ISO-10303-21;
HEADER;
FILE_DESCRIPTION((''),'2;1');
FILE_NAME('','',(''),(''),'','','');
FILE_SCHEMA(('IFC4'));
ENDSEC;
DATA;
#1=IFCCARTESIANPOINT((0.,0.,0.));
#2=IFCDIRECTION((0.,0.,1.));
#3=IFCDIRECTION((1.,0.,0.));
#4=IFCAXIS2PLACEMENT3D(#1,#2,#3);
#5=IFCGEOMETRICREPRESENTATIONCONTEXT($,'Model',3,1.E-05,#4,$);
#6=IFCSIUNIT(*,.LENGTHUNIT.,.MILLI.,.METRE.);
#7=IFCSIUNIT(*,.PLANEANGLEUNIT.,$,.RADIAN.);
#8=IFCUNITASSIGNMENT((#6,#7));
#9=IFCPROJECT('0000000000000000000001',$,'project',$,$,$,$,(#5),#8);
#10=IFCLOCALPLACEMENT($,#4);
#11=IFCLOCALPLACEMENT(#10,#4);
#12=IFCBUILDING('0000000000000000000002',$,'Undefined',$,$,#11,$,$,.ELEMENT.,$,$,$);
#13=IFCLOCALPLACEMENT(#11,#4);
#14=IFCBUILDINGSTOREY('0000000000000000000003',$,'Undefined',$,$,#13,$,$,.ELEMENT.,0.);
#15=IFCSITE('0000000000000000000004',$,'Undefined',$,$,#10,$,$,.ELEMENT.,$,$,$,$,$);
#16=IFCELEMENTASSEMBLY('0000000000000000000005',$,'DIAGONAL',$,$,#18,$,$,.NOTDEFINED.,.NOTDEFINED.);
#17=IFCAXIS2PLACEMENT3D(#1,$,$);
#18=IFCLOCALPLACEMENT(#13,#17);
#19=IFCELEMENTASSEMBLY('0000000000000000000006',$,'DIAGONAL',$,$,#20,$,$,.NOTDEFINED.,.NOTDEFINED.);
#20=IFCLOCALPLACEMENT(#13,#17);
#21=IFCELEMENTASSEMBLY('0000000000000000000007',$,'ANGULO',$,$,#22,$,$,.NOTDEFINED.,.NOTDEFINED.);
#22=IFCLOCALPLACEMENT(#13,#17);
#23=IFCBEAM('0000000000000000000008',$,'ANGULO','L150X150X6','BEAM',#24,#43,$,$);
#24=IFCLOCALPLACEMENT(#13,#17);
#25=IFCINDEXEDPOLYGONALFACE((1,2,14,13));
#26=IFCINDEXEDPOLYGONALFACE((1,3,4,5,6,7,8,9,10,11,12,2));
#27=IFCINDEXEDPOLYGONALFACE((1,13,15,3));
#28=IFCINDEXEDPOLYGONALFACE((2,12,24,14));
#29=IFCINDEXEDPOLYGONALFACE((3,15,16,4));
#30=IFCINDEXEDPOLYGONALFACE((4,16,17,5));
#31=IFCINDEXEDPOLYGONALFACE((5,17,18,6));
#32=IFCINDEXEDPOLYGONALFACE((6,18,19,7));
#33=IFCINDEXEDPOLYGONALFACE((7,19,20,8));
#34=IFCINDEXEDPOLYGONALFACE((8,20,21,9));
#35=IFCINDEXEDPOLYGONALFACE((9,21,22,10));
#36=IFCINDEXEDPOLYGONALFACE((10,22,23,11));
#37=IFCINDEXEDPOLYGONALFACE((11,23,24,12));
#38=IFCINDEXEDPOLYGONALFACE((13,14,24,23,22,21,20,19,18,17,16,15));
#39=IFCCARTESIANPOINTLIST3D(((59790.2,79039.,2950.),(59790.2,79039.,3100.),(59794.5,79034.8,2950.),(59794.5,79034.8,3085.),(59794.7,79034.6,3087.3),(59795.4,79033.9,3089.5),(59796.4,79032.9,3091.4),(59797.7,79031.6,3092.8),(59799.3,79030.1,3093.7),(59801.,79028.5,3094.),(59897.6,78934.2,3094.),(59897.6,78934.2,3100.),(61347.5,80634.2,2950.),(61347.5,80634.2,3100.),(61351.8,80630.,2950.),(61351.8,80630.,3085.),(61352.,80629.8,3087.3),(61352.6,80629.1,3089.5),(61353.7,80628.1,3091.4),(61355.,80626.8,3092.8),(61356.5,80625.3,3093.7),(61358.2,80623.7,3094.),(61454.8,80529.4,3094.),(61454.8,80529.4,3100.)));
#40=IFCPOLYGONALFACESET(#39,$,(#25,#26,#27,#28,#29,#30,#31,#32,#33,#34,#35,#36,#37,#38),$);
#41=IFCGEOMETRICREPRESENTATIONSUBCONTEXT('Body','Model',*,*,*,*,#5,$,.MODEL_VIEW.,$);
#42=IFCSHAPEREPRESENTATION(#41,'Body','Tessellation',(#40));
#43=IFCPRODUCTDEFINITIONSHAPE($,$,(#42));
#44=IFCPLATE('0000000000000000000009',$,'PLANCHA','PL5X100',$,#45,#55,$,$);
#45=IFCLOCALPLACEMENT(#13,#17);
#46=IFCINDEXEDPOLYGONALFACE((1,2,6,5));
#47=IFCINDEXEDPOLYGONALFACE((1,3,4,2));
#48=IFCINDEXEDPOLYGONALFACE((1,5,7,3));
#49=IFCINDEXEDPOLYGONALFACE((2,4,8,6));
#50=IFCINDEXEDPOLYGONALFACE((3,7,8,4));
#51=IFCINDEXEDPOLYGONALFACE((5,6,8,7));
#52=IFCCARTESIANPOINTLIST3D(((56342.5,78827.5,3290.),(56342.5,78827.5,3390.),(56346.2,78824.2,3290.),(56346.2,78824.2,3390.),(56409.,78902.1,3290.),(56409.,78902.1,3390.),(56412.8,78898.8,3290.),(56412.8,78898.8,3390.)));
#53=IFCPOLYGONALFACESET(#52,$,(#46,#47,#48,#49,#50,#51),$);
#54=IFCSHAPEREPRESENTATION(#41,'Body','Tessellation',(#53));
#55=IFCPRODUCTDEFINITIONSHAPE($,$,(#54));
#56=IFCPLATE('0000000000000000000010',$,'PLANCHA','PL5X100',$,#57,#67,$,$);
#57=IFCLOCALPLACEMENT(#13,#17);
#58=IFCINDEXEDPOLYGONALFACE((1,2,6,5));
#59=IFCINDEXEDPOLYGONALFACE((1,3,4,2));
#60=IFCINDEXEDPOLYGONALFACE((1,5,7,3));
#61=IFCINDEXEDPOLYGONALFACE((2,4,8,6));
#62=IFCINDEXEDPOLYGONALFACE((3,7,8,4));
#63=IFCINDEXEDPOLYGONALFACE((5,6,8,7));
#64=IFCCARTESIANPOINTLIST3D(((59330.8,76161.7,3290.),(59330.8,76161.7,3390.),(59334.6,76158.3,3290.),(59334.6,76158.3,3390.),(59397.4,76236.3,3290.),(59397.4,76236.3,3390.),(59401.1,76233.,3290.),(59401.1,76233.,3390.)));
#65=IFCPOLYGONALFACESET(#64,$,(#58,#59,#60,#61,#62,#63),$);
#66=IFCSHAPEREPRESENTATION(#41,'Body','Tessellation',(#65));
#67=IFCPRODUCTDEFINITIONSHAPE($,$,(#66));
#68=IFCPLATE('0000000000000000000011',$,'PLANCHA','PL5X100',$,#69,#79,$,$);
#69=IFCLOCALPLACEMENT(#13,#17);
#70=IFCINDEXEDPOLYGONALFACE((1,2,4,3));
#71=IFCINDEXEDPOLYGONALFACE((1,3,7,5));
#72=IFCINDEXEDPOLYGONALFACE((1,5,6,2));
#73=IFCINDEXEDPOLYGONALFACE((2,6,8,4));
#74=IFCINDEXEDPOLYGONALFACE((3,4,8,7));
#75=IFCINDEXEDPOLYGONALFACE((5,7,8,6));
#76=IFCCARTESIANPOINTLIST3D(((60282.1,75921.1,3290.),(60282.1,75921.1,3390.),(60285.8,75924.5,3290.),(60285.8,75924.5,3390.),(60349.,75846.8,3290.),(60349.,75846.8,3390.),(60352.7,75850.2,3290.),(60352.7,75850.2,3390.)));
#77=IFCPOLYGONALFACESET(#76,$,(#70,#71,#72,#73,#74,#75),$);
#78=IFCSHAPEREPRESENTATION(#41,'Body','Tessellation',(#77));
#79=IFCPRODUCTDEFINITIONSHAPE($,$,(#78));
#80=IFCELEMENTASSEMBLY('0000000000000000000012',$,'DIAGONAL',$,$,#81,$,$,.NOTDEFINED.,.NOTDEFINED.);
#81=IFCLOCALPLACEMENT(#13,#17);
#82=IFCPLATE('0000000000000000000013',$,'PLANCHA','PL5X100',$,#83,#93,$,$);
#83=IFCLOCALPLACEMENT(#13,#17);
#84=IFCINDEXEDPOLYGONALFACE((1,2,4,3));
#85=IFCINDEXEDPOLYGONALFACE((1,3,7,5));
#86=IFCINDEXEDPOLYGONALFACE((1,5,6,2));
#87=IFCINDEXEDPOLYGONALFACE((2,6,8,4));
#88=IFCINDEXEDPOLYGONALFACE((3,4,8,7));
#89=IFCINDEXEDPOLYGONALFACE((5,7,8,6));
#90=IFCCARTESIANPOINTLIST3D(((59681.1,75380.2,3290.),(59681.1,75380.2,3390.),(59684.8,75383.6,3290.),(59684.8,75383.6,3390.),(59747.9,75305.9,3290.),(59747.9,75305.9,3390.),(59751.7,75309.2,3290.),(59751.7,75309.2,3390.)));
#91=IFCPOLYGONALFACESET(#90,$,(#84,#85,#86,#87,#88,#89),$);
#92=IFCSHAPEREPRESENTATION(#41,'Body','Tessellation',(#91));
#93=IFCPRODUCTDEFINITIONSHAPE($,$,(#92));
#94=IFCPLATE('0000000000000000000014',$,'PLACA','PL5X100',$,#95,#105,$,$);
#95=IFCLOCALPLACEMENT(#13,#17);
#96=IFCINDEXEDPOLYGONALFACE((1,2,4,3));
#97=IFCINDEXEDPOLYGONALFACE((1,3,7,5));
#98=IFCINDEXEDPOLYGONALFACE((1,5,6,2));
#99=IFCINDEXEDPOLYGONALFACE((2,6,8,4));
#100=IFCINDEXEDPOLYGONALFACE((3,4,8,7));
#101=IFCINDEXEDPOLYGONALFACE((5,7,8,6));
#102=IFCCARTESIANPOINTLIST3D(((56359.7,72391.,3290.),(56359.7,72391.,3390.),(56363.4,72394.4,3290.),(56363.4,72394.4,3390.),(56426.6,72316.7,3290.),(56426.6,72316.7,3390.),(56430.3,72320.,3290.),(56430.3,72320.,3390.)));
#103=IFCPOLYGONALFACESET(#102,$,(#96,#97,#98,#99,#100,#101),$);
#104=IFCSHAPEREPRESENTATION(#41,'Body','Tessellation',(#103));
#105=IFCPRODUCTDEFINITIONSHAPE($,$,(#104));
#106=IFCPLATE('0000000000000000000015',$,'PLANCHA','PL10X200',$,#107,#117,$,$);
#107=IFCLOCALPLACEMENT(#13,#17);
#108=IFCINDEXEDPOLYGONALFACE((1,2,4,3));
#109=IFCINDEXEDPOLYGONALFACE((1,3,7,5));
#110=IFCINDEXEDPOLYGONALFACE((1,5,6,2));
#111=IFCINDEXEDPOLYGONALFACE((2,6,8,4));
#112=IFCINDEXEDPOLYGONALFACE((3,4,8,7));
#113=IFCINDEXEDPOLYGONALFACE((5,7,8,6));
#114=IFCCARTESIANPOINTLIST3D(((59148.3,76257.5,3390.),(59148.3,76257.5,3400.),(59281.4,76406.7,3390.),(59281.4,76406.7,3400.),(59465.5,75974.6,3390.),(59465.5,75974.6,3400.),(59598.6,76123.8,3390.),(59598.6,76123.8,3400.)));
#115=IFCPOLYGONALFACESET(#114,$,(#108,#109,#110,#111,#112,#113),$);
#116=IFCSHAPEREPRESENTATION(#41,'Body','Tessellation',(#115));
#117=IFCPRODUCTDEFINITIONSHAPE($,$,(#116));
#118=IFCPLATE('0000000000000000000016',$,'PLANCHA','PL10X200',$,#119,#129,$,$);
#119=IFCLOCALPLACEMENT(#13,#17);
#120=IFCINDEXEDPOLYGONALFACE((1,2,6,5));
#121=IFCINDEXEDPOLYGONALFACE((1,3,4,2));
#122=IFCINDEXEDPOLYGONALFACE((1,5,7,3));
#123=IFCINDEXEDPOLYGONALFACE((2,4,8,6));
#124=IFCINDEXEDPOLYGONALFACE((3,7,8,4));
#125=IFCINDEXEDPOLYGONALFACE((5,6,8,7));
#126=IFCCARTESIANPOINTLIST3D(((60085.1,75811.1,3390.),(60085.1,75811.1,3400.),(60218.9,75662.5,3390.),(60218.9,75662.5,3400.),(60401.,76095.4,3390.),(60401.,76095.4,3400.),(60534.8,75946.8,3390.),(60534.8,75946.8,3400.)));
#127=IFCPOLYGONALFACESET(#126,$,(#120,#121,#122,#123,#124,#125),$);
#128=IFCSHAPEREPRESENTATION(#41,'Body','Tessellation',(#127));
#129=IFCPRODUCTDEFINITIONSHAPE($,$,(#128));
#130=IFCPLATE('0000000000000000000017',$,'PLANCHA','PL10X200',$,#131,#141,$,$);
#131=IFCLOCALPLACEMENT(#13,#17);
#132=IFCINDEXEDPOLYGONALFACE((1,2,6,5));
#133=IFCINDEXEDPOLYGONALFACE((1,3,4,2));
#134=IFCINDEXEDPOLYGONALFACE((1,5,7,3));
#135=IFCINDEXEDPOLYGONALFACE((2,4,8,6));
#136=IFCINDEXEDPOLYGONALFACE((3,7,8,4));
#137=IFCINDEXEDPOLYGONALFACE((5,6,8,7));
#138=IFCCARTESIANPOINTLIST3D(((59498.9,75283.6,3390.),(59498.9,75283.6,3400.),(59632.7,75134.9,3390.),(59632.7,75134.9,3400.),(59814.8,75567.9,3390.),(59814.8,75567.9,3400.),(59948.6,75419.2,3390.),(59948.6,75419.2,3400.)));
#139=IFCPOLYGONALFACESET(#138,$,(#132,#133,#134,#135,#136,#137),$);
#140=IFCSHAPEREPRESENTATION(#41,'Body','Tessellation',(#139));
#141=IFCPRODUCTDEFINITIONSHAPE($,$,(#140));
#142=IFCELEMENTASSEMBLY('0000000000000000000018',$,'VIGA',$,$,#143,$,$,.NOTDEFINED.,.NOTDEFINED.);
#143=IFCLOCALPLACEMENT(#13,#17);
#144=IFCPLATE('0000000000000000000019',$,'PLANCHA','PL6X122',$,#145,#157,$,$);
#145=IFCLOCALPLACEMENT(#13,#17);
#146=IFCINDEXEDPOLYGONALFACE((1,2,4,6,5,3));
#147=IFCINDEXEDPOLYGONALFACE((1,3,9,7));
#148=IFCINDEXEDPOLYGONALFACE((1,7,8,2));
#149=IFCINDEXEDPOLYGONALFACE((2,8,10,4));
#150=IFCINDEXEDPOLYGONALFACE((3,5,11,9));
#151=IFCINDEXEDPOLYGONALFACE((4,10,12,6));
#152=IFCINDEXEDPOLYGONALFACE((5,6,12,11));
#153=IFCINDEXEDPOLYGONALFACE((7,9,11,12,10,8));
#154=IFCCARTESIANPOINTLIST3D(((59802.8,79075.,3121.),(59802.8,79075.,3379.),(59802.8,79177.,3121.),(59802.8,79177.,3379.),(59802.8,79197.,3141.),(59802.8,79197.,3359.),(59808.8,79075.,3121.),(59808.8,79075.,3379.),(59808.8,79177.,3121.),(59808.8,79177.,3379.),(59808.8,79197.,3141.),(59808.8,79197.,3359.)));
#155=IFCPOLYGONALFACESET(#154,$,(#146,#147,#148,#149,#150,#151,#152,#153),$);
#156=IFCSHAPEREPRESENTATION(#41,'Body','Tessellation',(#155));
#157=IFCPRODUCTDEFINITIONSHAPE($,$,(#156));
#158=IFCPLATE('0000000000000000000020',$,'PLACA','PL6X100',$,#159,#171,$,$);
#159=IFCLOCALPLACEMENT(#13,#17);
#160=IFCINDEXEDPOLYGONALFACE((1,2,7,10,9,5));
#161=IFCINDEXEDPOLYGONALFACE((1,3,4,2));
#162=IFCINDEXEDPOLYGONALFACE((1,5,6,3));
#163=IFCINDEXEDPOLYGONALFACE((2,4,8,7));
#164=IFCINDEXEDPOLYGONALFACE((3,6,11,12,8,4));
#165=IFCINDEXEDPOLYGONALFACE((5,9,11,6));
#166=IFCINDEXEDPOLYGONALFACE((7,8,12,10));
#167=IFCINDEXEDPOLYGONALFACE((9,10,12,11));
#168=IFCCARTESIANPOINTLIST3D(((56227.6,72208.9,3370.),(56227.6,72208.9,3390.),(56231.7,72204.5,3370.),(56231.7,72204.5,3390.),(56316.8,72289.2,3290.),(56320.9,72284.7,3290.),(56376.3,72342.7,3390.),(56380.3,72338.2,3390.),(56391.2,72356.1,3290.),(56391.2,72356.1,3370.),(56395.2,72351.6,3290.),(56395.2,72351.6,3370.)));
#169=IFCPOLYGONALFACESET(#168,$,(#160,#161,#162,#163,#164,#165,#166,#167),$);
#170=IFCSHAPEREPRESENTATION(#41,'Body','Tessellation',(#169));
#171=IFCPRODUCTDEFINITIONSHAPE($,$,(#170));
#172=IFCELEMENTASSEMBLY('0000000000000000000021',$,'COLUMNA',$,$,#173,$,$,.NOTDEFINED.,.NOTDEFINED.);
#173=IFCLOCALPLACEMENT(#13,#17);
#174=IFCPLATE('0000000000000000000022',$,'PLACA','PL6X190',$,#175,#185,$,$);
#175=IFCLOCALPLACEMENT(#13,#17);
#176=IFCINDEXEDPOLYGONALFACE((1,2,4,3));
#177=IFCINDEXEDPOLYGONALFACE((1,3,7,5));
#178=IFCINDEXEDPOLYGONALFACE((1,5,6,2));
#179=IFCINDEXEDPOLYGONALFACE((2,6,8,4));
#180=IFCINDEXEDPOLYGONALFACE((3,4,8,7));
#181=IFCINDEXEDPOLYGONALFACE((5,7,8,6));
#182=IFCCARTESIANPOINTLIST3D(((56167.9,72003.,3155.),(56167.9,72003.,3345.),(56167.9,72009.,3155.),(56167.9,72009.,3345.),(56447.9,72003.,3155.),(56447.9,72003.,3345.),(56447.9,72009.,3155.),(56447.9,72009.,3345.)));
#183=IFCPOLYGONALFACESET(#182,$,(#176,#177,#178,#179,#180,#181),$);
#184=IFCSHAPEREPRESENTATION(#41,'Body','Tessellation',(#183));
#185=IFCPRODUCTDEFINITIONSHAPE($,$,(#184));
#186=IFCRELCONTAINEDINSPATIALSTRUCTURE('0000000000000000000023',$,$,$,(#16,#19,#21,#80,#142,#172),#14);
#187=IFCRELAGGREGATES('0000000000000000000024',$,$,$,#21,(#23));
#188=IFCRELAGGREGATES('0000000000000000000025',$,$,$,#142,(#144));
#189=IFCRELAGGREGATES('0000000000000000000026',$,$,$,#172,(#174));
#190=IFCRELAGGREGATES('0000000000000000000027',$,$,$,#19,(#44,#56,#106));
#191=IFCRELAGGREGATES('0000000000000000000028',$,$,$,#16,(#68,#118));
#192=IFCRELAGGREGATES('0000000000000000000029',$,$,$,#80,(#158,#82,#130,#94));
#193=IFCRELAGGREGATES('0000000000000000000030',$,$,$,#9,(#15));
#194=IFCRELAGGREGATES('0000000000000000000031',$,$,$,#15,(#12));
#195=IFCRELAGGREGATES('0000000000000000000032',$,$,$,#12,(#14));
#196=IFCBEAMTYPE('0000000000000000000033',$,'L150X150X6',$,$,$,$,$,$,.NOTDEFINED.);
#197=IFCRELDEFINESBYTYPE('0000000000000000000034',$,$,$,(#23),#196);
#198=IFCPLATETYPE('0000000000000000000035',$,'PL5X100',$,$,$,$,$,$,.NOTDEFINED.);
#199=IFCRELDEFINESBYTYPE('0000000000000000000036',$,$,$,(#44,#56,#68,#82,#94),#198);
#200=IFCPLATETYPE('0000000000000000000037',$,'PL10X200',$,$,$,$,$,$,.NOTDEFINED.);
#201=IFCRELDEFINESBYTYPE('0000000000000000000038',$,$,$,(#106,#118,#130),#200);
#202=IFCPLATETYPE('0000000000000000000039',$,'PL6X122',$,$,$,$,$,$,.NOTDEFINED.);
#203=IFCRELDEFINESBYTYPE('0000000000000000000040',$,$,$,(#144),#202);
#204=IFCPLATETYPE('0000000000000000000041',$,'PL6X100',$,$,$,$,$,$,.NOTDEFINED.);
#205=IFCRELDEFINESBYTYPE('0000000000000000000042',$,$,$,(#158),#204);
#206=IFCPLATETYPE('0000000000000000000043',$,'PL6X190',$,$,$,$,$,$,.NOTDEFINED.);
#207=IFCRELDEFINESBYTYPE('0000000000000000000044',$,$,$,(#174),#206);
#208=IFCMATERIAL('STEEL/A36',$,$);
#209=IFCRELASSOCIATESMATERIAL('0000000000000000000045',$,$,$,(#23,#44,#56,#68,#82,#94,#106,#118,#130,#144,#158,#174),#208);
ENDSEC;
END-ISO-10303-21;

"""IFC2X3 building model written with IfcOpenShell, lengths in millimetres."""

from ifc_helpers import new_model, si_unit, frame, origin_with_axes, origin_2d_with_axis, place, context, subcontext, project, spatial, polyline, l_section, outline, extrude, material, type_object, element, aggregate, save


model = new_model("IFC2X3")

# Units and contexts
model_context = context("Model", 3, precision=1e-05, world=origin_with_axes())
body_context = subcontext(model_context, "Body", "Model", "MODEL_VIEW")
ifc_project = project(units=[si_unit("LENGTHUNIT", "METRE", prefix="MILLI"), si_unit("PLANEANGLEUNIT", "RADIAN")], contexts=[model_context])

# Site, building, storey
site_placement = place(None, origin_with_axes())
site = spatial("IfcSite", under=ifc_project, at=site_placement, Name="Undefined", CompositionType="ELEMENT")
building_placement = place(site_placement, origin_with_axes())
building = spatial("IfcBuilding", under=site, at=building_placement, Name="Undefined", CompositionType="ELEMENT")
storey_placement = place(building_placement, origin_with_axes())
storey = spatial("IfcBuildingStorey", under=building, at=storey_placement, Name="Undefined", CompositionType="ELEMENT", Elevation=0.0)

# Element assemblies, beam
ifc_material_1 = material(Name="STEEL/A36")
assembly_1_placement = place(storey_placement, origin_with_axes())
assembly_1 = element("IfcElementAssembly", 1, at=assembly_1_placement, inside=storey, Name="DIAGONAL", AssemblyPlace="NOTDEFINED", PredefinedType="NOTDEFINED")
assembly_2_placement = place(storey_placement, origin_with_axes())
assembly_2 = element("IfcElementAssembly", 2, at=assembly_2_placement, inside=storey, Name="DIAGONAL", AssemblyPlace="NOTDEFINED", PredefinedType="NOTDEFINED")
assembly_3_placement = place(storey_placement, origin_with_axes())
assembly_3 = element("IfcElementAssembly", 3, at=assembly_3_placement, inside=storey, Name="ANGULO", AssemblyPlace="NOTDEFINED", PredefinedType="NOTDEFINED")
beam_type_1 = type_object("IfcBeamType", Name="L150X150X6", PredefinedType="NOTDEFINED")
beam_1_placement = place(assembly_3_placement, frame((59843.9, 78986.6, 3025.0), z_axis=(0.71557, -0.698541, 0.0), x_axis=(0.698541, 0.715571, 0.0)))
beam_1 = element("IfcBeam", 4, at=beam_1_placement, type_object=beam_type_1, material=ifc_material_1, Name="ANGULO", Description="L150X150X6", ObjectType="BEAM", context=body_context, shape_type="SweptSolid", body=[
    extrude(l_section(Depth=150.0, Width=150.0, Thickness=6.0, FilletRadius=9.0, at=origin_2d_with_axis()), frame((2229.3, 0.0, 0.0), z_axis=(-1.0, 0.0, 0.0), x_axis=(0.0, -1.0, 0.0)), (0.0, 0.0, 1.0), 2229.3),
])
aggregate(assembly_3, [beam_1])

# Plates
plate_type_1 = type_object("IfcPlateType", Name="PL5X100", PredefinedType="NOTDEFINED")
plate_1_placement = place(assembly_2_placement, frame((56377.6, 78863.1, 3390.0), z_axis=(0.74623, -0.665688, 0.0), x_axis=(0.0, 0.0, -1.0)))
plate_1 = element("IfcPlate", 5, at=plate_1_placement, type_object=plate_type_1, material=ifc_material_1, Name="PLANCHA", Description="PL5X100", context=body_context, shape_type="SweptSolid", body=[
    extrude(outline(polyline([(0.0, -50.0), (0.0, 50.0), (100.0, 50.0), (100.0, -50.0), (0.0, -50.0)])), frame((0.0, 0.0, -2.5), z_axis=(0.0, 0.0, 1.0), x_axis=(1.0, 0.0, 0.0)), (0.0, 0.0, 1.0), 5.0),
])
plate_2_placement = place(assembly_2_placement, frame((59366.0, 76197.3, 3390.0), z_axis=(-0.74623, 0.665688, 0.0), x_axis=(0.0, 0.0, -1.0)))
plate_2 = element("IfcPlate", 6, at=plate_2_placement, type_object=plate_type_1, material=ifc_material_1, Name="PLANCHA", Description="PL5X100", context=body_context, shape_type="SweptSolid", body=[
    extrude(outline(polyline([(0.0, -50.0), (0.0, 50.0), (100.0, 50.0), (100.0, -50.0), (0.0, -50.0)])), frame((0.0, 0.0, -2.5), z_axis=(0.0, 0.0, 1.0), x_axis=(1.0, 0.0, 0.0)), (0.0, 0.0, 1.0), 5.0),
])
plate_3_placement = place(assembly_1_placement, frame((60317.4, 75885.7, 3390.0), z_axis=(0.743294, 0.668965, 0.0), x_axis=(0.0, 0.0, -1.0)))
plate_3 = element("IfcPlate", 7, at=plate_3_placement, type_object=plate_type_1, material=ifc_material_1, Name="PLANCHA", Description="PL5X100", context=body_context, shape_type="SweptSolid", body=[
    extrude(outline(polyline([(0.0, -50.0), (0.0, 50.0), (100.0, 50.0), (100.0, -50.0), (0.0, -50.0)])), frame((0.0, 0.0, -2.5), z_axis=(0.0, 0.0, 1.0), x_axis=(1.0, 0.0, 0.0)), (0.0, 0.0, 1.0), 5.0),
])

# Element assembly, plates
assembly_4_placement = place(storey_placement, origin_with_axes())
assembly_4 = element("IfcElementAssembly", 8, at=assembly_4_placement, inside=storey, Name="DIAGONAL", AssemblyPlace="NOTDEFINED", PredefinedType="NOTDEFINED")
plate_4_placement = place(assembly_4_placement, frame((59716.4, 75344.7, 3390.0), z_axis=(-0.743294, -0.668964, 0.0), x_axis=(0.0, 0.0, -1.0)))
plate_4 = element("IfcPlate", 9, at=plate_4_placement, type_object=plate_type_1, material=ifc_material_1, Name="PLANCHA", Description="PL5X100", context=body_context, shape_type="SweptSolid", body=[
    extrude(outline(polyline([(0.0, -50.0), (0.0, 50.0), (100.0, 50.0), (100.0, -50.0), (0.0, -50.0)])), frame((0.0, 0.0, -2.5), z_axis=(0.0, 0.0, 1.0), x_axis=(1.0, 0.0, 0.0)), (0.0, 0.0, 1.0), 5.0),
])
plate_5_placement = place(assembly_4_placement, frame((56428.5, 72318.4, 3390.0), z_axis=(0.743294, 0.668965, 0.0), x_axis=(0.0, 0.0, -1.0)))
plate_5 = element("IfcPlate", 10, at=plate_5_placement, type_object=plate_type_1, material=ifc_material_1, Name="PLACA", Description="PL5X100", context=body_context, shape_type="SweptSolid", body=[
    extrude(outline(polyline([(0.0, 0.0), (100.0, 0.0), (100.0, 100.0), (0.0, 100.0), (0.0, 0.0)])), frame((0.0, 0.0, -2.5), z_axis=(0.0, 0.0, 1.0), x_axis=(1.0, 0.0, 0.0)), (0.0, 0.0, 1.0), 5.0),
])

# Plates
plate_type_2 = type_object("IfcPlateType", Name="PL10X200", PredefinedType="NOTDEFINED")
plate_6_placement = place(assembly_2_placement, frame((59532.0, 76049.2, 3395.0), z_axis=(0.0, 0.0, 1.0), x_axis=(-0.74623, 0.665688, 0.0)))
plate_6 = element("IfcPlate", 11, at=plate_6_placement, type_object=plate_type_2, material=ifc_material_1, Name="PLANCHA", Description="PL10X200", context=body_context, shape_type="SweptSolid", body=[
    extrude(outline(polyline([(0.0, -100.0), (0.0, 100.0), (425.0, 100.0), (425.0, -100.0), (0.0, -100.0)])), frame((0.0, 0.0, -5.0), z_axis=(0.0, 0.0, 1.0), x_axis=(1.0, 0.0, 0.0)), (0.0, 0.0, 1.0), 10.0),
])
plate_7_placement = place(assembly_1_placement, frame((60152.0, 75736.8, 3395.0), z_axis=(0.0, 0.0, 1.0), x_axis=(0.743294, 0.668965, 0.0)))
plate_7 = element("IfcPlate", 12, at=plate_7_placement, type_object=plate_type_2, material=ifc_material_1, Name="PLANCHA", Description="PL10X200", context=body_context, shape_type="SweptSolid", body=[
    extrude(outline(polyline([(0.0, -100.0), (0.0, 100.0), (425.0, 100.0), (425.0, -100.0), (0.0, -100.0)])), frame((0.0, 0.0, -5.0), z_axis=(0.0, 0.0, 1.0), x_axis=(1.0, 0.0, 0.0)), (0.0, 0.0, 1.0), 10.0),
])
plate_8_placement = place(assembly_4_placement, frame((59881.7, 75493.6, 3395.0), z_axis=(0.0, 0.0, 1.0), x_axis=(-0.743294, -0.668964, 0.0)))
plate_8 = element("IfcPlate", 13, at=plate_8_placement, type_object=plate_type_2, material=ifc_material_1, Name="PLANCHA", Description="PL10X200", context=body_context, shape_type="SweptSolid", body=[
    extrude(outline(polyline([(0.0, -100.0), (0.0, 100.0), (425.0, 100.0), (425.0, -100.0), (0.0, -100.0)])), frame((0.0, 0.0, -5.0), z_axis=(0.0, 0.0, 1.0), x_axis=(1.0, 0.0, 0.0)), (0.0, 0.0, 1.0), 10.0),
])

# Element assembly, plate
assembly_5_placement = place(storey_placement, origin_with_axes())
assembly_5 = element("IfcElementAssembly", 14, at=assembly_5_placement, inside=storey, Name="VIGA", AssemblyPlace="NOTDEFINED", PredefinedType="NOTDEFINED")
plate_type_3 = type_object("IfcPlateType", Name="PL6X122", PredefinedType="NOTDEFINED")
plate_9_placement = place(assembly_5_placement, frame((59805.8, 79075.0, 3121.0), z_axis=(1.0, 0.0, 0.0), x_axis=(0.0, 1.0, 0.0)))
plate_9 = element("IfcPlate", 15, at=plate_9_placement, type_object=plate_type_3, material=ifc_material_1, Name="PLANCHA", Description="PL6X122", context=body_context, shape_type="SweptSolid", body=[
    extrude(outline(polyline([(0.0, 0.0), (102.0, 0.0), (122.0, 20.0), (122.0, 238.0), (102.0, 258.0), (0.0, 258.0), (0.0, 0.0)])), frame((0.0, 0.0, -3.0), z_axis=(0.0, 0.0, 1.0), x_axis=(1.0, 0.0, 0.0)), (0.0, 0.0, 1.0), 6.0),
])
aggregate(assembly_5, [plate_9])

# Plate
plate_type_4 = type_object("IfcPlateType", Name="PL6X100", PredefinedType="NOTDEFINED")
plate_10_placement = place(assembly_4_placement, frame((56229.7, 72206.7, 3290.0), z_axis=(0.668964, -0.743294, 0.0), x_axis=(0.743294, 0.668965, 0.0)))
plate_10 = element("IfcPlate", 16, at=plate_10_placement, type_object=plate_type_4, material=ifc_material_1, Name="PLACA", Description="PL6X100", context=body_context, shape_type="SweptSolid", body=[
    extrude(outline(polyline([(0.0, 80.0), (120.0, 0.0), (220.0, 0.0), (220.0, 80.0), (200.0, 100.0), (0.0, 100.0), (0.0, 80.0)])), frame((0.0, 0.0, -3.0), z_axis=(0.0, 0.0, 1.0), x_axis=(1.0, 0.0, 0.0)), (0.0, 0.0, 1.0), 6.0),
])

# Element assembly, plate
assembly_6_placement = place(storey_placement, origin_with_axes())
assembly_6 = element("IfcElementAssembly", 17, at=assembly_6_placement, inside=storey, Name="COLUMNA", AssemblyPlace="NOTDEFINED", PredefinedType="NOTDEFINED")
plate_type_5 = type_object("IfcPlateType", Name="PL6X190", PredefinedType="NOTDEFINED")
plate_11_placement = place(assembly_6_placement, frame((56447.9, 72006.0, 3250.0), z_axis=(0.0, 1.0, 0.0), x_axis=(-1.0, 0.0, 0.0)))
plate_11 = element("IfcPlate", 18, at=plate_11_placement, type_object=plate_type_5, material=ifc_material_1, Name="PLACA", Description="PL6X190", context=body_context, shape_type="SweptSolid", body=[
    extrude(outline(polyline([(0.0, -95.0), (0.0, 95.0), (280.0, 95.0), (280.0, -95.0), (0.0, -95.0)])), frame((0.0, 0.0, -3.0), z_axis=(0.0, 0.0, 1.0), x_axis=(1.0, 0.0, 0.0)), (0.0, 0.0, 1.0), 6.0),
])

aggregate(assembly_6, [plate_11])
aggregate(assembly_2, [plate_1, plate_2, plate_6])
aggregate(assembly_1, [plate_3, plate_7])
aggregate(assembly_4, [plate_10, plate_4, plate_8, plate_5])

save(model, "model.ifc")
